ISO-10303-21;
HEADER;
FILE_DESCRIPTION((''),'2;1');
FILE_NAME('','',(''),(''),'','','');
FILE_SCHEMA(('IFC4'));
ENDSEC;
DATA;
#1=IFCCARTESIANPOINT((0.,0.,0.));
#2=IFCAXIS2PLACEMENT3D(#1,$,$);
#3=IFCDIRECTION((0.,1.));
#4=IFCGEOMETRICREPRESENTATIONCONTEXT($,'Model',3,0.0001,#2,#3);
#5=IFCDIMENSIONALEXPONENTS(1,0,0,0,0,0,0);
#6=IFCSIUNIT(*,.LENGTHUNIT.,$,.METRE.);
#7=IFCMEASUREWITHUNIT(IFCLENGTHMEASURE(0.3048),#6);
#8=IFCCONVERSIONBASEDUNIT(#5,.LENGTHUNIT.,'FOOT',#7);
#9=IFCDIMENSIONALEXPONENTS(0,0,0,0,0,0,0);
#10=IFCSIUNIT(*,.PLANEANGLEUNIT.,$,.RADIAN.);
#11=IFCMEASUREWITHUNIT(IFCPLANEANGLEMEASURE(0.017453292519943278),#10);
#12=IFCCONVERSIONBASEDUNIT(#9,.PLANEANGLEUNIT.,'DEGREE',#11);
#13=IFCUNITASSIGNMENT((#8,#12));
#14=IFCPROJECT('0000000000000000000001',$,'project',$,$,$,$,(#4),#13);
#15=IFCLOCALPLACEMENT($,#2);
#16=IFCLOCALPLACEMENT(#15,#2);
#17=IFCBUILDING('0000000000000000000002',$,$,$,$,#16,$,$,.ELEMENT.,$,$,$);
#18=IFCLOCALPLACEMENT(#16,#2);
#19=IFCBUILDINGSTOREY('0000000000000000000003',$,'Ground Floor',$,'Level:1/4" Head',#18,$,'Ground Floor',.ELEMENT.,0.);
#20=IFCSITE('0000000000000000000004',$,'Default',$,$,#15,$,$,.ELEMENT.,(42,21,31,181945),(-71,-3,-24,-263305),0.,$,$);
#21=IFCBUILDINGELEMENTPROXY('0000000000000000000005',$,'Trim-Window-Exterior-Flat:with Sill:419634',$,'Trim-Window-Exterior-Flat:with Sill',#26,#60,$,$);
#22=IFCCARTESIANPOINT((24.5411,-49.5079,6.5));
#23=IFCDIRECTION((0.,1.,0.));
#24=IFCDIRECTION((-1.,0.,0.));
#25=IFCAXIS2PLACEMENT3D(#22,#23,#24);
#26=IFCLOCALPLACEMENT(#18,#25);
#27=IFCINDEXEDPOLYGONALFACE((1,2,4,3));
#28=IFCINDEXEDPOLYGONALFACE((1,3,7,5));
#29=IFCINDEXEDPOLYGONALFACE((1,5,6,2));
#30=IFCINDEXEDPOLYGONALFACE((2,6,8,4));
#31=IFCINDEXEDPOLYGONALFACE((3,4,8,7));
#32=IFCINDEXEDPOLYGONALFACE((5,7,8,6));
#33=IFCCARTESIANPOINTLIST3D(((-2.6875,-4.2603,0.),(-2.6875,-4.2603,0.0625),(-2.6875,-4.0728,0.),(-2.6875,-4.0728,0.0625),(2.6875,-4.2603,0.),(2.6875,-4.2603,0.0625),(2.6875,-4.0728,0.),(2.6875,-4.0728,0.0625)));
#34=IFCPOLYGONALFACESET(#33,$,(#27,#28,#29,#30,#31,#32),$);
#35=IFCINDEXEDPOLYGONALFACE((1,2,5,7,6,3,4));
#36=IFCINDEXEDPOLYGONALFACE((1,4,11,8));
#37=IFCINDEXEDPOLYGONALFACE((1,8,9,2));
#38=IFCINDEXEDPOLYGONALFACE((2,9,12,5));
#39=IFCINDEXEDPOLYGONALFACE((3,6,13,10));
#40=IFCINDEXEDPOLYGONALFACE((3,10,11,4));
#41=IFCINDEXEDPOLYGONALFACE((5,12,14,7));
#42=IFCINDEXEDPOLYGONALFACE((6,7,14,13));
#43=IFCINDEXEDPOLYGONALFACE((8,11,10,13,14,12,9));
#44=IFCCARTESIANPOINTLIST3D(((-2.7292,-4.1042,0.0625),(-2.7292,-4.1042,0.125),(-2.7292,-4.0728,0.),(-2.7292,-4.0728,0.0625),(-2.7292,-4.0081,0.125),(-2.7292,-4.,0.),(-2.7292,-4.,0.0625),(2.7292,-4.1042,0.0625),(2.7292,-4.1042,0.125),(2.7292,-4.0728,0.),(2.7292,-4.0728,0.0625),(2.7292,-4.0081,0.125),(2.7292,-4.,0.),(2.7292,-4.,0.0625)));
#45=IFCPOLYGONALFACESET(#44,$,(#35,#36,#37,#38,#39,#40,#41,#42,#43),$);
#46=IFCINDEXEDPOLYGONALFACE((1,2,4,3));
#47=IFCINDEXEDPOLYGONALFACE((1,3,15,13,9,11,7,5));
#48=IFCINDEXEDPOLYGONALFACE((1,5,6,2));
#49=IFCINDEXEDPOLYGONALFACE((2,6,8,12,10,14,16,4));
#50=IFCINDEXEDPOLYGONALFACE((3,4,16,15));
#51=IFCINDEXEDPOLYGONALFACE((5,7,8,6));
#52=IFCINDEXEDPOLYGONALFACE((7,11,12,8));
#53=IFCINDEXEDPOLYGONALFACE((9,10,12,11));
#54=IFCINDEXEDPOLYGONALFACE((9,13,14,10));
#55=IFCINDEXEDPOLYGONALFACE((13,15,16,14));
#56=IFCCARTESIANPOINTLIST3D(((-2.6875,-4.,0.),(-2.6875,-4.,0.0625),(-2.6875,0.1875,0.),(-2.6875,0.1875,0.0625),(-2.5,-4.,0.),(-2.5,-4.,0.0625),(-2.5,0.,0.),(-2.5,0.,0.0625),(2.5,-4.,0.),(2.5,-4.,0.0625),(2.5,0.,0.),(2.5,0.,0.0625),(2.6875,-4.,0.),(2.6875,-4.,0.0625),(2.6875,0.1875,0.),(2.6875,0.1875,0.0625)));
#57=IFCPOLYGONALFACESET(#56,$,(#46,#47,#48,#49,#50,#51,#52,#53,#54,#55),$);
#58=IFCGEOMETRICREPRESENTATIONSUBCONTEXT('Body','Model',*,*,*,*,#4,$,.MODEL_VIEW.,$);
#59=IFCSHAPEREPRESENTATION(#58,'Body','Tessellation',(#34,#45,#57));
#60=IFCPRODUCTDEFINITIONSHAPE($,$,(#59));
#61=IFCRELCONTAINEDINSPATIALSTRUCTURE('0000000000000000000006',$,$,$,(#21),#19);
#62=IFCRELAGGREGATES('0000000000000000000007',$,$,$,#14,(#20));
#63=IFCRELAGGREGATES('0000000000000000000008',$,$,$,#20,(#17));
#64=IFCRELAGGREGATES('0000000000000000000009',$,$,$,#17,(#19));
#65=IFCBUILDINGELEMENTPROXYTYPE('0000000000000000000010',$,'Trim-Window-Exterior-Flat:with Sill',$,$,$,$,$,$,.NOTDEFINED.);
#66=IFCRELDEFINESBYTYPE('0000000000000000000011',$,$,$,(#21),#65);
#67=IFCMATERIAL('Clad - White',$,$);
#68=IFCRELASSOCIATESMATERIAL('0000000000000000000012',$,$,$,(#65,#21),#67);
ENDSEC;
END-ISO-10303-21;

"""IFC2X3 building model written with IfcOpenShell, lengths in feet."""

from ifc_helpers import new_model, entity, si_unit, converted_unit, direction, frame, origin, origin_2d_with_axis, place, context, subcontext, project, spatial, polyline, rectangle, outline, extrude, source, transform, mapped, material, type_object, type_shapes, element, save


model = new_model("IFC2X3")

# Units and contexts
model_context = context("Model", 3, precision=0.0001, world=origin(), true_north=direction((0.0, 1.0)))
body_context = subcontext(model_context, "Body", "Model", "MODEL_VIEW")
ifc_project = project(units=[converted_unit("LENGTHUNIT", "FOOT", entity("IfcLengthMeasure", 0.3048), si_unit("LENGTHUNIT", "METRE"), dimensions=[1, 0, 0, 0, 0, 0, 0]), converted_unit("PLANEANGLEUNIT", "DEGREE", entity("IfcPlaneAngleMeasure", 0.017453292519943278), si_unit("PLANEANGLEUNIT", "RADIAN"), dimensions=[0, 0, 0, 0, 0, 0, 0])], contexts=[model_context])

# Site, building, storey
site_placement = place(None, origin())
site = spatial("IfcSite", under=ifc_project, at=site_placement, Name="Default", CompositionType="ELEMENT", RefLatitude=(42, 21, 31, 181945), RefLongitude=(-71, -3, -24, -263305), RefElevation=0.0)
building_placement = place(site_placement, origin())
building = spatial("IfcBuilding", under=site, at=building_placement, CompositionType="ELEMENT")
storey_placement = place(building_placement, origin())
storey = spatial("IfcBuildingStorey", under=building, at=storey_placement, Name="Ground Floor", ObjectType="Level:1/4\" Head", LongName="Ground Floor", CompositionType="ELEMENT", Elevation=0.0)

# Building element proxy
ifc_material_1 = material(Name="Clad - White")
building_element_proxy_type_1 = type_object("IfcBuildingElementProxyType", Name="Trim-Window-Exterior-Flat:with Sill", PredefinedType="NOTDEFINED", material=ifc_material_1)
shared_shape_1 = source(origin(), body_context, "Body", "SweptSolid", [
    extrude(rectangle(XDim=5.375, YDim=0.1875, at=origin_2d_with_axis()), frame((0.0, -4.1665, 0.0), z_axis=(0.0, 0.0, 1.0), x_axis=(-1.0, 0.0, 0.0)), (0.0, 0.0, 1.0), 0.0625),
    extrude(outline(polyline([(-0.0625, -0.0525), (0.0, -0.0525), (0.0, -0.0211), (0.0625, -0.0211), (0.0625, 0.0517), (0.0, 0.0517), (-0.0625, 0.0436), (-0.0625, -0.0525)])), frame((-2.7292, -4.0517, 0.0625), z_axis=(1.0, 0.0, 0.0), x_axis=(0.0, 0.0, -1.0)), (0.0, 0.0, 1.0), 5.4583),
    extrude(outline(polyline([(-2.1406, -2.6875), (2.0469, -2.6875), (2.0469, -2.5), (-1.9531, -2.5), (-1.9531, 2.5), (2.0469, 2.5), (2.0469, 2.6875), (-2.1406, 2.6875), (-2.1406, -2.6875)])), frame((0.0, -1.9531, 0.0), z_axis=(0.0, 0.0, 1.0), x_axis=(0.0, -1.0, 0.0)), (0.0, 0.0, 1.0), 0.0625),
])
type_shapes(building_element_proxy_type_1, [shared_shape_1])
proxy_1_placement = place(storey_placement, frame((24.5411, -49.5079, 6.5), z_axis=(0.0, 1.0, 0.0), x_axis=(-1.0, 0.0, 0.0)))
element("IfcBuildingElementProxy", 1, at=proxy_1_placement, inside=storey, type_object=building_element_proxy_type_1, material=ifc_material_1, Name="Trim-Window-Exterior-Flat:with Sill:419634", ObjectType="Trim-Window-Exterior-Flat:with Sill", context=body_context, shape_type="MappedRepresentation", body=[
    mapped(shared_shape_1, transform((0.0, 0.0, 0.0), scale=1.0)),
])

save(model, "model.ifc")
